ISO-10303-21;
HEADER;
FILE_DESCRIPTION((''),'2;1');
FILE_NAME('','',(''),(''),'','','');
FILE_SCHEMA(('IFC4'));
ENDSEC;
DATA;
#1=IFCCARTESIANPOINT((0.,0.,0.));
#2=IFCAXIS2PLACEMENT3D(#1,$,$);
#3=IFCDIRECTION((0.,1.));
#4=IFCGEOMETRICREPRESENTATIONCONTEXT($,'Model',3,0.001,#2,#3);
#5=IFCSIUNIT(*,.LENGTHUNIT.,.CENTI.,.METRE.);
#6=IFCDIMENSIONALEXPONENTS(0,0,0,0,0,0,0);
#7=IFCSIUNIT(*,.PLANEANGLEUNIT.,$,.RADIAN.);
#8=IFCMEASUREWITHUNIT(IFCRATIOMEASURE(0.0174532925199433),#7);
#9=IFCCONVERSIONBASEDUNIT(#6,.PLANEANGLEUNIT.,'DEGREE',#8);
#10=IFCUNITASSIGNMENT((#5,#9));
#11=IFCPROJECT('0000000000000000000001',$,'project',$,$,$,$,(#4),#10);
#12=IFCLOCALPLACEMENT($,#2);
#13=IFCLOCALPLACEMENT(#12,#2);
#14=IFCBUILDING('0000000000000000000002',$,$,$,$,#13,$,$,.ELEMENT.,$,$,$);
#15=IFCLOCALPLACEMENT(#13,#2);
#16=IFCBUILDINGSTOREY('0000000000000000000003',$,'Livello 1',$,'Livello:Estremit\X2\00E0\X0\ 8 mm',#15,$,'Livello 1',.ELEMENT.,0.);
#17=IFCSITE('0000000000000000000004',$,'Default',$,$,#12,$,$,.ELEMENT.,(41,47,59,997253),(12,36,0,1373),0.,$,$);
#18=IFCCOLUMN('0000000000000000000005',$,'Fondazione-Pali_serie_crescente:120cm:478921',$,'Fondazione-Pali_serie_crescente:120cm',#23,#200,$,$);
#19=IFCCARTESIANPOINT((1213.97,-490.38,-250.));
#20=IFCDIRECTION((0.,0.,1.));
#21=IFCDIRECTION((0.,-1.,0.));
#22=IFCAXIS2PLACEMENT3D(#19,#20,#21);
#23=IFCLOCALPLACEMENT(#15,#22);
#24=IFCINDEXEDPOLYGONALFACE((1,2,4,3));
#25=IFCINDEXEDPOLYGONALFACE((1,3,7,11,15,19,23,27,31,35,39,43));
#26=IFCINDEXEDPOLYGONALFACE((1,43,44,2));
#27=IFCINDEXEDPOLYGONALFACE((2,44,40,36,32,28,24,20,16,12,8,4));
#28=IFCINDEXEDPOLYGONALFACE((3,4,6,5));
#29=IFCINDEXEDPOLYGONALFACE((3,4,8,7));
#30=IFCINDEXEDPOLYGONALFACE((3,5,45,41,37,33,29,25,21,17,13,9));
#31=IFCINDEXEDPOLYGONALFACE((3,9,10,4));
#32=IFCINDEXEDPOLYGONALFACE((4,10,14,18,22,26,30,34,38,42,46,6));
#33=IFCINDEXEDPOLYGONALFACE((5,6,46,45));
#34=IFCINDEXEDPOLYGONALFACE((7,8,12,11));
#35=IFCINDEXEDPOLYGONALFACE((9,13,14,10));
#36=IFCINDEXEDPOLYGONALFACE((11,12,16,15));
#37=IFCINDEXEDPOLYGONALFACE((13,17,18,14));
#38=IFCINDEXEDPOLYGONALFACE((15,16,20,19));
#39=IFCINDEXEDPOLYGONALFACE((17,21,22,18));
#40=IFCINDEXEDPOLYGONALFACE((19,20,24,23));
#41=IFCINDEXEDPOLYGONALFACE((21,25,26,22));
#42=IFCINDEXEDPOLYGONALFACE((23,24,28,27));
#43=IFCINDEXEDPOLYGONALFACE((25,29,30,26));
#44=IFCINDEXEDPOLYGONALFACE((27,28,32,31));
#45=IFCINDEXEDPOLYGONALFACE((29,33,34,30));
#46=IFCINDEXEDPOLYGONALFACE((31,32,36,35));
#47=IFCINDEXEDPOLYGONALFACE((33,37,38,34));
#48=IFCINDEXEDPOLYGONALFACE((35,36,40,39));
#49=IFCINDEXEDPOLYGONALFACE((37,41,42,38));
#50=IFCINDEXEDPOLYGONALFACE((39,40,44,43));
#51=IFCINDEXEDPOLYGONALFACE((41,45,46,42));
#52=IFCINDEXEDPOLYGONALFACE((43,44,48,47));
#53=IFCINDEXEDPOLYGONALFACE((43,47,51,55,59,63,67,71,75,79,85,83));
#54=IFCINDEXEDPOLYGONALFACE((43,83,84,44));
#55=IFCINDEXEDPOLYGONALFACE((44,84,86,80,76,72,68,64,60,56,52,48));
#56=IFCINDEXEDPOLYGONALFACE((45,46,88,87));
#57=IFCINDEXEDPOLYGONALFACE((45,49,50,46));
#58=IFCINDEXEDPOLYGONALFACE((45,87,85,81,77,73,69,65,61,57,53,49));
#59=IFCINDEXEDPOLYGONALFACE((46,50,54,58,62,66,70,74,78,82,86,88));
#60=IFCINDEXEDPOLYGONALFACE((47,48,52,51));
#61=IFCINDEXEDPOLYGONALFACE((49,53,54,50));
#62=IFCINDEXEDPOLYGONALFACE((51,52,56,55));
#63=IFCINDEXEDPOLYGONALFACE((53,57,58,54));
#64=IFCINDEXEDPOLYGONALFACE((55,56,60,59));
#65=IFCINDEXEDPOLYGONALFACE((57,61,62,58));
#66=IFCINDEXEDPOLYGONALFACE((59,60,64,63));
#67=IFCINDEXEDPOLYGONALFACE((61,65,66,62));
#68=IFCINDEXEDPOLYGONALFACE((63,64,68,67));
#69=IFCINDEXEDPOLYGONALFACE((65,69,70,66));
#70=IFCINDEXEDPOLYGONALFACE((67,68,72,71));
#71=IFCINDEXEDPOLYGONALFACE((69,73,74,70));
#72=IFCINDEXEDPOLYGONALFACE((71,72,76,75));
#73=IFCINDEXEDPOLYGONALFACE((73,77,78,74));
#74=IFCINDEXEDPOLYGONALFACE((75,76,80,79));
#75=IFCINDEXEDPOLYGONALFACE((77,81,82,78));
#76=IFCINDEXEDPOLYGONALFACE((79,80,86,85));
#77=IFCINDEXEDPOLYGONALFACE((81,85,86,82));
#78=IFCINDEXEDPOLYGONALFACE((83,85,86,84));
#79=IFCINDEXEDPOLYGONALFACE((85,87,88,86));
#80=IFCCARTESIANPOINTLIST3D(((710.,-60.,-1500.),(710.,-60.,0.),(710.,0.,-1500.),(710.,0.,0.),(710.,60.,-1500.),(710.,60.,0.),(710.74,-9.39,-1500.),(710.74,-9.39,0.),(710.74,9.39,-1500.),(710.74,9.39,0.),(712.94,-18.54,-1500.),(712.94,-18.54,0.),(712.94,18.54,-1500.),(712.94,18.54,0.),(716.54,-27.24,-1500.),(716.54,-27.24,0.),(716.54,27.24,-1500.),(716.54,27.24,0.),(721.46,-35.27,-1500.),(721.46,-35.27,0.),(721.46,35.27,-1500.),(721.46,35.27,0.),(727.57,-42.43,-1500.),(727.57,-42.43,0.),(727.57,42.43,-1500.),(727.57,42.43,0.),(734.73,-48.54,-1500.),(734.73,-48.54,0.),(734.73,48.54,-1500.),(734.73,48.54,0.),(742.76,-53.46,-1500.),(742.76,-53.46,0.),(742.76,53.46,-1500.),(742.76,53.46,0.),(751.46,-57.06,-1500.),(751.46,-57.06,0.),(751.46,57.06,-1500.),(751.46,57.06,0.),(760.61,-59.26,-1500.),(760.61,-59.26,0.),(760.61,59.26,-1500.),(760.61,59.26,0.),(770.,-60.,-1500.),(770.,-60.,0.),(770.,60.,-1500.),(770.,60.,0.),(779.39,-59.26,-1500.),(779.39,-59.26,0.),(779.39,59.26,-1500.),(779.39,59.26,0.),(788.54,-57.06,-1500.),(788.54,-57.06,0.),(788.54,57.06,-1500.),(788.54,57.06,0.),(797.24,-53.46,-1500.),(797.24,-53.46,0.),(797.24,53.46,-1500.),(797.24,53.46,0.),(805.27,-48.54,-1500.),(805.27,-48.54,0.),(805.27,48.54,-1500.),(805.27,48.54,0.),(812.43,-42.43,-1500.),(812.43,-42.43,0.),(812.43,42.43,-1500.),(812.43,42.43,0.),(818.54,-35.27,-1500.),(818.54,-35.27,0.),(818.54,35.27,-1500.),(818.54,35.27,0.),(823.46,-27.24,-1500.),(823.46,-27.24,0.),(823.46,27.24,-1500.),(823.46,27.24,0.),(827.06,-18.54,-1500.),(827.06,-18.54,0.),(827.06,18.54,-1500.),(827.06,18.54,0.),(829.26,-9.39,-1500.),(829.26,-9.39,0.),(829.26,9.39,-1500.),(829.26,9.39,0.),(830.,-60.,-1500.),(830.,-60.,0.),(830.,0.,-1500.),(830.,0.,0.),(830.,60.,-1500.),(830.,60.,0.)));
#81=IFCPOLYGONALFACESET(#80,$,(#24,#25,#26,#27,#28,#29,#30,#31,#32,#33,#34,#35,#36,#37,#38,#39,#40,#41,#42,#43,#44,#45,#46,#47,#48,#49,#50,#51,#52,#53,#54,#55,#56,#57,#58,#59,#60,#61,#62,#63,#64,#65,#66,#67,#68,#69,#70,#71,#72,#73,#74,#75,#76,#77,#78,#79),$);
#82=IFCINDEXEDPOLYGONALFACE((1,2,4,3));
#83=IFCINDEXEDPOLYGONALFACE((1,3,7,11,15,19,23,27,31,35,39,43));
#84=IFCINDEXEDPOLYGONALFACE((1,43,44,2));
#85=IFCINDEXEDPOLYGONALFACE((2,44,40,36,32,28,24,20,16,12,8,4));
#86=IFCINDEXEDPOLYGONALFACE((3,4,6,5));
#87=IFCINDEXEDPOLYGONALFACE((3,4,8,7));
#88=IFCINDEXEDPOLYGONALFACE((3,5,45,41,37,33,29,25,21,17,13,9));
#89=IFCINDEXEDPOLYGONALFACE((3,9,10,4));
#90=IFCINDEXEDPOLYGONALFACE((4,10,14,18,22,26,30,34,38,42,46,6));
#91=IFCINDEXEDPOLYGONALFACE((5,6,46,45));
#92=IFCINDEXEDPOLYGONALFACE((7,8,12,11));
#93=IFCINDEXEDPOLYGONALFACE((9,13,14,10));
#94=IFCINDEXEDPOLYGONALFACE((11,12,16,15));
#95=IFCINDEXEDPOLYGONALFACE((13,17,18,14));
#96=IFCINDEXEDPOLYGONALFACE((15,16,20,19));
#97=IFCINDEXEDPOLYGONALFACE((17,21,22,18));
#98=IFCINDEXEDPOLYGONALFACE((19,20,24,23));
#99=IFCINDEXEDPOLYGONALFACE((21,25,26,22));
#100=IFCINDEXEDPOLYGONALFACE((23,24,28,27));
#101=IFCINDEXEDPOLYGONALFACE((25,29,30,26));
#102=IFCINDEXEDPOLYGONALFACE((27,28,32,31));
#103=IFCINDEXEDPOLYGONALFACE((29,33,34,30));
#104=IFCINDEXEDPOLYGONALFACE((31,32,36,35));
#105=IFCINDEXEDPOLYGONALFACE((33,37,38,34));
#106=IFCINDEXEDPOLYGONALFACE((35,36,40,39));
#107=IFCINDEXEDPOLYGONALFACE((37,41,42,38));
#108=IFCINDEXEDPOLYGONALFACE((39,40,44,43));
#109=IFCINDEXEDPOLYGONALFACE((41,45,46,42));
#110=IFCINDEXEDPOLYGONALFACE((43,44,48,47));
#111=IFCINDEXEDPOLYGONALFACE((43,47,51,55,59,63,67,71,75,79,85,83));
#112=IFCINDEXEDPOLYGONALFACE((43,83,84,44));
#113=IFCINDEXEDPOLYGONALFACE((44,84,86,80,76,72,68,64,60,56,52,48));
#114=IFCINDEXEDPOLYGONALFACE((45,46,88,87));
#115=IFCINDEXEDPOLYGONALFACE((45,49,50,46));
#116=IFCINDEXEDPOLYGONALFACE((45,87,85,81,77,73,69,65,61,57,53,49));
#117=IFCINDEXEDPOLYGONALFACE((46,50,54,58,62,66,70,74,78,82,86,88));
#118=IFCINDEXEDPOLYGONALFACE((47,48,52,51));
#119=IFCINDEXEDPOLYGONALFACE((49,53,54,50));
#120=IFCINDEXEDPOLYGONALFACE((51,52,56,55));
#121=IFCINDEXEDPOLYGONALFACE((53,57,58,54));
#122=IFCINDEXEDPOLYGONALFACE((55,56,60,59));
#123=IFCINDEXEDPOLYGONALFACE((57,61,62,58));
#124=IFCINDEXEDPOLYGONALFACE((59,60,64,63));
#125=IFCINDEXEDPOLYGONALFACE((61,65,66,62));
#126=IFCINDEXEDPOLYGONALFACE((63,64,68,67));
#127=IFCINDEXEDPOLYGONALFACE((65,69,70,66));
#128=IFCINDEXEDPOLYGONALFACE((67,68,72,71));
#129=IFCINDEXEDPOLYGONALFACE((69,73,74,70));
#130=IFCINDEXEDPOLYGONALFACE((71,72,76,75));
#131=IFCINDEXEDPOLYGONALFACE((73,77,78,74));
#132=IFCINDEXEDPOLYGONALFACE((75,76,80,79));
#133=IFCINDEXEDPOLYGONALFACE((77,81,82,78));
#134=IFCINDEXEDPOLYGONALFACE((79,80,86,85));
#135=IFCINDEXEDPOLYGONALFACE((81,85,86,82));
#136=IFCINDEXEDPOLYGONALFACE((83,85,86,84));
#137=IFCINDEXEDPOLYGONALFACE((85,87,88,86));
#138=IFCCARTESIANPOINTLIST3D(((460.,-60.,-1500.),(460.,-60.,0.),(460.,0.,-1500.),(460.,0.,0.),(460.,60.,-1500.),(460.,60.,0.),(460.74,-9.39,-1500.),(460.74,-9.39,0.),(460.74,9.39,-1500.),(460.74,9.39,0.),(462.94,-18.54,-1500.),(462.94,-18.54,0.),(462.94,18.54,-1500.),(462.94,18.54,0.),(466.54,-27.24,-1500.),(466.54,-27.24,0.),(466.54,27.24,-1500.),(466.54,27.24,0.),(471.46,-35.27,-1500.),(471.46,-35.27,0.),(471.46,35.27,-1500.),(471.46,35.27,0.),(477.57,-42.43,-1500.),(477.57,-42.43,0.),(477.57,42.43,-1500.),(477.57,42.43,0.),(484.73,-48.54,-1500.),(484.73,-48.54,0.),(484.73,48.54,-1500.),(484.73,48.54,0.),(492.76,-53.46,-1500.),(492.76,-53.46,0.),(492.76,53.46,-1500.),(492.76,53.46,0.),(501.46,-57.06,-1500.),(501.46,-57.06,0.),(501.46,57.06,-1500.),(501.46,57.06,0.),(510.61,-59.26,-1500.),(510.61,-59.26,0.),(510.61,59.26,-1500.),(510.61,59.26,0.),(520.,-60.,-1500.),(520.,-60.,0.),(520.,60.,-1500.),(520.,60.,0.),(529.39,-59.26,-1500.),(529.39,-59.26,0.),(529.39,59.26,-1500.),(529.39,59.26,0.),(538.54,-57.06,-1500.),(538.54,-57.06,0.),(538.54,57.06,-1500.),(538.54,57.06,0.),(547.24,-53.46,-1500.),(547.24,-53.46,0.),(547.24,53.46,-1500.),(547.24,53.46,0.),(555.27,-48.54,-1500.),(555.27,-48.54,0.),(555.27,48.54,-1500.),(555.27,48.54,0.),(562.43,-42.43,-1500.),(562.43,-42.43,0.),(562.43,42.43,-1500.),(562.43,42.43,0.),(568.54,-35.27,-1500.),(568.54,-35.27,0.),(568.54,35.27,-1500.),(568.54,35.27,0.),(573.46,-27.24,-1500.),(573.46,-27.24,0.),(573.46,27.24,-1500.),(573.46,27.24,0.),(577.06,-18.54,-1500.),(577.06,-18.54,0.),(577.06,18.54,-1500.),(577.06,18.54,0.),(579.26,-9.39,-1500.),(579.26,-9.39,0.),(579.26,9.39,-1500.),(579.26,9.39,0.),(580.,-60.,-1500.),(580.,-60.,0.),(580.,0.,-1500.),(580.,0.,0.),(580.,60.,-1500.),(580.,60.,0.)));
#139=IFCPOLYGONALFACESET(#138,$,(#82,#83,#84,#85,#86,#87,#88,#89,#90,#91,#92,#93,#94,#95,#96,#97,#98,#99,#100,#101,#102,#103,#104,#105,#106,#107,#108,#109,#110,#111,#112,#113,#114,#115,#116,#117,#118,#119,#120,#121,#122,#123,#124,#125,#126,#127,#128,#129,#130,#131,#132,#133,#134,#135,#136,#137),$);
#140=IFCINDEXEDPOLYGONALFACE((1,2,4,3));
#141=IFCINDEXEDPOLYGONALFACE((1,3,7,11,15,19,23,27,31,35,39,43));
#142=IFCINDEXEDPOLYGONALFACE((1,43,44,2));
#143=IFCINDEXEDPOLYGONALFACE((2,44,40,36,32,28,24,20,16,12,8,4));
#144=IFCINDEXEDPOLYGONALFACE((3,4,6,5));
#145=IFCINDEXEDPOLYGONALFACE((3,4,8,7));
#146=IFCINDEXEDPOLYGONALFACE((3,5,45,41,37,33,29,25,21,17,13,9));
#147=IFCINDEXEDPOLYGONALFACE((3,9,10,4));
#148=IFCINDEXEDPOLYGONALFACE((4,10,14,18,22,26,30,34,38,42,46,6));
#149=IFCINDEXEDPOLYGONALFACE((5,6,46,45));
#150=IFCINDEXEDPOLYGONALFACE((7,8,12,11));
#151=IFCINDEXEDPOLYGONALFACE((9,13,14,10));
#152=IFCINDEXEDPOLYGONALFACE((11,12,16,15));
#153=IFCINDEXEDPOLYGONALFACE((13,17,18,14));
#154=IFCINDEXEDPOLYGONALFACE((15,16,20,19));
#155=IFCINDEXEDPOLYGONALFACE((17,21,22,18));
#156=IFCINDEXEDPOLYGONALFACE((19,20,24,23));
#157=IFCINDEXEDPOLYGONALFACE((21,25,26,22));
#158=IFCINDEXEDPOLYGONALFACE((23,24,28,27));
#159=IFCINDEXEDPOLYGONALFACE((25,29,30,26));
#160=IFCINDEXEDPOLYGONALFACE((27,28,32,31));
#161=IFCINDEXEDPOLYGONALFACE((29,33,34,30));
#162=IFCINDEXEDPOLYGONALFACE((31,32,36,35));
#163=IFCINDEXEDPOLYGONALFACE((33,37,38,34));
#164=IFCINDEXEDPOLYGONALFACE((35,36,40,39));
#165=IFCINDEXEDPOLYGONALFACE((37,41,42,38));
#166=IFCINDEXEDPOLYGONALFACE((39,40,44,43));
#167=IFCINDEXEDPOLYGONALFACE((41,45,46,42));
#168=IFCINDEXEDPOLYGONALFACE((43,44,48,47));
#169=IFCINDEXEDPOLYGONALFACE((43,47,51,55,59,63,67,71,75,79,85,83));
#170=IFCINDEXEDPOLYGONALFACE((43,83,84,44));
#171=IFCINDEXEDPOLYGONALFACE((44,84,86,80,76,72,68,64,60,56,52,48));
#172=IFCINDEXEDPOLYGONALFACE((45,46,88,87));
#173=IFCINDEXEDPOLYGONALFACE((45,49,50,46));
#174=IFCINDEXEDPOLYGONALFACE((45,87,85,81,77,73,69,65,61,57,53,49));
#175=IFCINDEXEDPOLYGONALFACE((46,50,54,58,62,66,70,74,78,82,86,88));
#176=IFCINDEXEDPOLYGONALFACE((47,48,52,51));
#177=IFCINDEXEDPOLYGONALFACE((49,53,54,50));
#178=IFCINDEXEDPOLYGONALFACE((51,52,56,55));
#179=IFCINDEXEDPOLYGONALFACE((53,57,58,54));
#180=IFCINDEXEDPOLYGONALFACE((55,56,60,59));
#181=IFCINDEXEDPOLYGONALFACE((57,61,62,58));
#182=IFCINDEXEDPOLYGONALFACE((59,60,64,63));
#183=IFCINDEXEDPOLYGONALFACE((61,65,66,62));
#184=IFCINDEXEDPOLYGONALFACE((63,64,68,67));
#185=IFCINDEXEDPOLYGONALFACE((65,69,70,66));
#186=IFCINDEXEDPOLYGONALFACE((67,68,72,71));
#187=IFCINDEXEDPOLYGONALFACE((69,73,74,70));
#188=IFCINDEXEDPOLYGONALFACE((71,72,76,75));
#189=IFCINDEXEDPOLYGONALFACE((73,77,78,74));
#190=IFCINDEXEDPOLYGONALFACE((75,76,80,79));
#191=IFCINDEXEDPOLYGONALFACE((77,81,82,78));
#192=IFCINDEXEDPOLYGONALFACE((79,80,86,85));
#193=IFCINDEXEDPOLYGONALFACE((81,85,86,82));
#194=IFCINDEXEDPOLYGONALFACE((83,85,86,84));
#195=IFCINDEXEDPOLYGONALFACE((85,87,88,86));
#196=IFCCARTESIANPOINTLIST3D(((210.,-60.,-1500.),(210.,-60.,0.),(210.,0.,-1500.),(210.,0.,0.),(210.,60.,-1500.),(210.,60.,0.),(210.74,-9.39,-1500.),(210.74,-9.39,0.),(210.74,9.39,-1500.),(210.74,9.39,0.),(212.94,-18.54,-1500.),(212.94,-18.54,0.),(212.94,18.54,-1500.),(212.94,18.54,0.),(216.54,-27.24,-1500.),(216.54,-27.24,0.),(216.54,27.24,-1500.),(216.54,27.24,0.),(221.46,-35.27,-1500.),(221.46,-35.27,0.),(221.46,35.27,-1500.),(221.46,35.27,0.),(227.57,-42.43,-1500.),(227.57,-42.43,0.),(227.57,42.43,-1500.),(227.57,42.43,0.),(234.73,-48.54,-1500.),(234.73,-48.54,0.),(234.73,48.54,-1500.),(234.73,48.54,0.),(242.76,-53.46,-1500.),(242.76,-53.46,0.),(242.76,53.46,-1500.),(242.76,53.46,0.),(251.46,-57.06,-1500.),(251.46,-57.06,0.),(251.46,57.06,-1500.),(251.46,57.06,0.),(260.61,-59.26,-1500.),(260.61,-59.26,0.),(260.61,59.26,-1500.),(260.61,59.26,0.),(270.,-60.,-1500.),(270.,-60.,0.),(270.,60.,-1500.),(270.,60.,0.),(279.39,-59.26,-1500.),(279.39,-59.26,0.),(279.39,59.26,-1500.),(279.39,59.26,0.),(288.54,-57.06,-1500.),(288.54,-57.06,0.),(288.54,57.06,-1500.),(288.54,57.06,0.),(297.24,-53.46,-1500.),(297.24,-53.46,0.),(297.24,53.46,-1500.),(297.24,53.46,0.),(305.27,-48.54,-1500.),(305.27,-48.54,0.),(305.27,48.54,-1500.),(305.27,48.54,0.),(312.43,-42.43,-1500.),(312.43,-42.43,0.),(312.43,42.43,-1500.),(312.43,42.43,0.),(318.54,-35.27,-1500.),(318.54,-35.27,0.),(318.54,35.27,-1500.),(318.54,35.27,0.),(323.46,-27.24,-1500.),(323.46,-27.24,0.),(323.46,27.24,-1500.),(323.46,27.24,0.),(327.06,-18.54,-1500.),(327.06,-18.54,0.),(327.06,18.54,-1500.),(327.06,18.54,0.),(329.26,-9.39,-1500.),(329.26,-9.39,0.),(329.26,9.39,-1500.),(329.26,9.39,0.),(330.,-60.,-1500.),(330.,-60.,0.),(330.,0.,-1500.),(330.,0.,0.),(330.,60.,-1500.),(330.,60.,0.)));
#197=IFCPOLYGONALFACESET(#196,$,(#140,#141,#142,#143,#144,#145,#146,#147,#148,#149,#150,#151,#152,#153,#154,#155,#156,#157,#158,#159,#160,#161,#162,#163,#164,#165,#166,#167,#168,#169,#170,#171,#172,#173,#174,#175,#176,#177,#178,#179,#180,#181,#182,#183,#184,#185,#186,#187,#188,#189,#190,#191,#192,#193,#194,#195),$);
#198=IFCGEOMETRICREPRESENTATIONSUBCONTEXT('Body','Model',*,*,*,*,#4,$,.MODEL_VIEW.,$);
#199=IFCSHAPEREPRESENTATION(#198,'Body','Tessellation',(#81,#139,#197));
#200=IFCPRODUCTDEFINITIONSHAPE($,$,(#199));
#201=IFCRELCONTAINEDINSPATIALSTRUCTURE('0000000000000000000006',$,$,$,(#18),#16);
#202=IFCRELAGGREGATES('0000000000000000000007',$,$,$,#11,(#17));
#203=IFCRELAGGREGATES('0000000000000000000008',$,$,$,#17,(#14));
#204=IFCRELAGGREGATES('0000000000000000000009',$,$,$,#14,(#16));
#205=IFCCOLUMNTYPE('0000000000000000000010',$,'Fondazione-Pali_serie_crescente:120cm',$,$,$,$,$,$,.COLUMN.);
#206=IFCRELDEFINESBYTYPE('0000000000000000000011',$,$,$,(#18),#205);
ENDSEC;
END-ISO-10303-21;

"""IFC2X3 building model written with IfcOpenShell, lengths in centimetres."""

from ifc_helpers import new_model, entity, si_unit, converted_unit, direction, frame, frame_2d, origin, origin_2d_with_axis, place, context, subcontext, project, spatial, rectangle, circle, extrude, boolean, source, transform, mapped, type_object, type_shapes, element, save


model = new_model("IFC2X3")

# Units and contexts
model_context = context("Model", 3, precision=0.001, world=origin(), true_north=direction((0.0, 1.0)))
body_context = subcontext(model_context, "Body", "Model", "MODEL_VIEW")
ifc_project = project(units=[si_unit("LENGTHUNIT", "METRE", prefix="CENTI"), converted_unit("PLANEANGLEUNIT", "DEGREE", entity("IfcRatioMeasure", 0.0174532925199433), si_unit("PLANEANGLEUNIT", "RADIAN"), dimensions=[0, 0, 0, 0, 0, 0, 0])], contexts=[model_context])

# Site, building, storey
site_placement = place(None, origin())
site = spatial("IfcSite", under=ifc_project, at=site_placement, Name="Default", CompositionType="ELEMENT", RefLatitude=(41, 47, 59, 997253), RefLongitude=(12, 36, 0, 1373), RefElevation=0.0)
building_placement = place(site_placement, origin())
building = spatial("IfcBuilding", under=site, at=building_placement, CompositionType="ELEMENT")
storey_placement = place(building_placement, origin())
storey = spatial("IfcBuildingStorey", under=building, at=storey_placement, Name="Livello 1", ObjectType="Livello:Estremità 8 mm", LongName="Livello 1", CompositionType="ELEMENT", Elevation=0.0)

# Column
column_type_1 = type_object("IfcColumnType", Name="Fondazione-Pali_serie_crescente:120cm", PredefinedType="COLUMN")
shared_shape_1 = source(origin(), body_context, "Body", "SweptSolid", [
    boolean("DIFFERENCE", extrude(rectangle(XDim=1500.0, YDim=120.0, at=origin_2d_with_axis()), frame((710.0, 0.0, -750.0), z_axis=(1.0, 0.0, 0.0), x_axis=(0.0, 0.0, -1.0)), (0.0, 0.0, 1.0), 120.0), extrude(circle(Radius=60.0, at=frame_2d((0.0, 0.0), x_axis=(1.0, 0.0))), frame((770.0, 0.0, 0.0)), (0.0, 0.0, -1.0), 1500.0)),
    boolean("DIFFERENCE", extrude(rectangle(XDim=1500.0, YDim=120.0, at=origin_2d_with_axis()), frame((460.0, 0.0, -750.0), z_axis=(1.0, 0.0, 0.0), x_axis=(0.0, 0.0, -1.0)), (0.0, 0.0, 1.0), 120.0), extrude(circle(Radius=60.0, at=frame_2d((0.0, 0.0), x_axis=(1.0, 0.0))), frame((520.0, 0.0, 0.0)), (0.0, 0.0, -1.0), 1500.0)),
    boolean("DIFFERENCE", extrude(rectangle(XDim=1500.0, YDim=120.0, at=origin_2d_with_axis()), frame((210.0, 0.0, -750.0), z_axis=(1.0, 0.0, 0.0), x_axis=(0.0, 0.0, -1.0)), (0.0, 0.0, 1.0), 120.0), extrude(circle(Radius=60.0, at=frame_2d((0.0, 0.0), x_axis=(1.0, 0.0))), frame((270.0, 0.0, 0.0)), (0.0, 0.0, -1.0), 1500.0)),
])
type_shapes(column_type_1, [shared_shape_1])
for number, where, z_axis, x_axis, name in (
    (1, (1213.97, -490.38, -250.0), (0.0, 0.0, 1.0), (0.0, -1.0, 0.0), "Fondazione-Pali_serie_crescente:120cm:478921"),
):
    element("IfcColumn", number, at=place(storey_placement, frame(where, z_axis=z_axis, x_axis=x_axis)), inside=storey, type_object=column_type_1, Name=name, ObjectType="Fondazione-Pali_serie_crescente:120cm", context=body_context, shape_type="MappedRepresentation", body=[
        mapped(shared_shape_1, transform((0.0, 0.0, 0.0), scale=1.0)),
    ])

save(model, "model.ifc")
